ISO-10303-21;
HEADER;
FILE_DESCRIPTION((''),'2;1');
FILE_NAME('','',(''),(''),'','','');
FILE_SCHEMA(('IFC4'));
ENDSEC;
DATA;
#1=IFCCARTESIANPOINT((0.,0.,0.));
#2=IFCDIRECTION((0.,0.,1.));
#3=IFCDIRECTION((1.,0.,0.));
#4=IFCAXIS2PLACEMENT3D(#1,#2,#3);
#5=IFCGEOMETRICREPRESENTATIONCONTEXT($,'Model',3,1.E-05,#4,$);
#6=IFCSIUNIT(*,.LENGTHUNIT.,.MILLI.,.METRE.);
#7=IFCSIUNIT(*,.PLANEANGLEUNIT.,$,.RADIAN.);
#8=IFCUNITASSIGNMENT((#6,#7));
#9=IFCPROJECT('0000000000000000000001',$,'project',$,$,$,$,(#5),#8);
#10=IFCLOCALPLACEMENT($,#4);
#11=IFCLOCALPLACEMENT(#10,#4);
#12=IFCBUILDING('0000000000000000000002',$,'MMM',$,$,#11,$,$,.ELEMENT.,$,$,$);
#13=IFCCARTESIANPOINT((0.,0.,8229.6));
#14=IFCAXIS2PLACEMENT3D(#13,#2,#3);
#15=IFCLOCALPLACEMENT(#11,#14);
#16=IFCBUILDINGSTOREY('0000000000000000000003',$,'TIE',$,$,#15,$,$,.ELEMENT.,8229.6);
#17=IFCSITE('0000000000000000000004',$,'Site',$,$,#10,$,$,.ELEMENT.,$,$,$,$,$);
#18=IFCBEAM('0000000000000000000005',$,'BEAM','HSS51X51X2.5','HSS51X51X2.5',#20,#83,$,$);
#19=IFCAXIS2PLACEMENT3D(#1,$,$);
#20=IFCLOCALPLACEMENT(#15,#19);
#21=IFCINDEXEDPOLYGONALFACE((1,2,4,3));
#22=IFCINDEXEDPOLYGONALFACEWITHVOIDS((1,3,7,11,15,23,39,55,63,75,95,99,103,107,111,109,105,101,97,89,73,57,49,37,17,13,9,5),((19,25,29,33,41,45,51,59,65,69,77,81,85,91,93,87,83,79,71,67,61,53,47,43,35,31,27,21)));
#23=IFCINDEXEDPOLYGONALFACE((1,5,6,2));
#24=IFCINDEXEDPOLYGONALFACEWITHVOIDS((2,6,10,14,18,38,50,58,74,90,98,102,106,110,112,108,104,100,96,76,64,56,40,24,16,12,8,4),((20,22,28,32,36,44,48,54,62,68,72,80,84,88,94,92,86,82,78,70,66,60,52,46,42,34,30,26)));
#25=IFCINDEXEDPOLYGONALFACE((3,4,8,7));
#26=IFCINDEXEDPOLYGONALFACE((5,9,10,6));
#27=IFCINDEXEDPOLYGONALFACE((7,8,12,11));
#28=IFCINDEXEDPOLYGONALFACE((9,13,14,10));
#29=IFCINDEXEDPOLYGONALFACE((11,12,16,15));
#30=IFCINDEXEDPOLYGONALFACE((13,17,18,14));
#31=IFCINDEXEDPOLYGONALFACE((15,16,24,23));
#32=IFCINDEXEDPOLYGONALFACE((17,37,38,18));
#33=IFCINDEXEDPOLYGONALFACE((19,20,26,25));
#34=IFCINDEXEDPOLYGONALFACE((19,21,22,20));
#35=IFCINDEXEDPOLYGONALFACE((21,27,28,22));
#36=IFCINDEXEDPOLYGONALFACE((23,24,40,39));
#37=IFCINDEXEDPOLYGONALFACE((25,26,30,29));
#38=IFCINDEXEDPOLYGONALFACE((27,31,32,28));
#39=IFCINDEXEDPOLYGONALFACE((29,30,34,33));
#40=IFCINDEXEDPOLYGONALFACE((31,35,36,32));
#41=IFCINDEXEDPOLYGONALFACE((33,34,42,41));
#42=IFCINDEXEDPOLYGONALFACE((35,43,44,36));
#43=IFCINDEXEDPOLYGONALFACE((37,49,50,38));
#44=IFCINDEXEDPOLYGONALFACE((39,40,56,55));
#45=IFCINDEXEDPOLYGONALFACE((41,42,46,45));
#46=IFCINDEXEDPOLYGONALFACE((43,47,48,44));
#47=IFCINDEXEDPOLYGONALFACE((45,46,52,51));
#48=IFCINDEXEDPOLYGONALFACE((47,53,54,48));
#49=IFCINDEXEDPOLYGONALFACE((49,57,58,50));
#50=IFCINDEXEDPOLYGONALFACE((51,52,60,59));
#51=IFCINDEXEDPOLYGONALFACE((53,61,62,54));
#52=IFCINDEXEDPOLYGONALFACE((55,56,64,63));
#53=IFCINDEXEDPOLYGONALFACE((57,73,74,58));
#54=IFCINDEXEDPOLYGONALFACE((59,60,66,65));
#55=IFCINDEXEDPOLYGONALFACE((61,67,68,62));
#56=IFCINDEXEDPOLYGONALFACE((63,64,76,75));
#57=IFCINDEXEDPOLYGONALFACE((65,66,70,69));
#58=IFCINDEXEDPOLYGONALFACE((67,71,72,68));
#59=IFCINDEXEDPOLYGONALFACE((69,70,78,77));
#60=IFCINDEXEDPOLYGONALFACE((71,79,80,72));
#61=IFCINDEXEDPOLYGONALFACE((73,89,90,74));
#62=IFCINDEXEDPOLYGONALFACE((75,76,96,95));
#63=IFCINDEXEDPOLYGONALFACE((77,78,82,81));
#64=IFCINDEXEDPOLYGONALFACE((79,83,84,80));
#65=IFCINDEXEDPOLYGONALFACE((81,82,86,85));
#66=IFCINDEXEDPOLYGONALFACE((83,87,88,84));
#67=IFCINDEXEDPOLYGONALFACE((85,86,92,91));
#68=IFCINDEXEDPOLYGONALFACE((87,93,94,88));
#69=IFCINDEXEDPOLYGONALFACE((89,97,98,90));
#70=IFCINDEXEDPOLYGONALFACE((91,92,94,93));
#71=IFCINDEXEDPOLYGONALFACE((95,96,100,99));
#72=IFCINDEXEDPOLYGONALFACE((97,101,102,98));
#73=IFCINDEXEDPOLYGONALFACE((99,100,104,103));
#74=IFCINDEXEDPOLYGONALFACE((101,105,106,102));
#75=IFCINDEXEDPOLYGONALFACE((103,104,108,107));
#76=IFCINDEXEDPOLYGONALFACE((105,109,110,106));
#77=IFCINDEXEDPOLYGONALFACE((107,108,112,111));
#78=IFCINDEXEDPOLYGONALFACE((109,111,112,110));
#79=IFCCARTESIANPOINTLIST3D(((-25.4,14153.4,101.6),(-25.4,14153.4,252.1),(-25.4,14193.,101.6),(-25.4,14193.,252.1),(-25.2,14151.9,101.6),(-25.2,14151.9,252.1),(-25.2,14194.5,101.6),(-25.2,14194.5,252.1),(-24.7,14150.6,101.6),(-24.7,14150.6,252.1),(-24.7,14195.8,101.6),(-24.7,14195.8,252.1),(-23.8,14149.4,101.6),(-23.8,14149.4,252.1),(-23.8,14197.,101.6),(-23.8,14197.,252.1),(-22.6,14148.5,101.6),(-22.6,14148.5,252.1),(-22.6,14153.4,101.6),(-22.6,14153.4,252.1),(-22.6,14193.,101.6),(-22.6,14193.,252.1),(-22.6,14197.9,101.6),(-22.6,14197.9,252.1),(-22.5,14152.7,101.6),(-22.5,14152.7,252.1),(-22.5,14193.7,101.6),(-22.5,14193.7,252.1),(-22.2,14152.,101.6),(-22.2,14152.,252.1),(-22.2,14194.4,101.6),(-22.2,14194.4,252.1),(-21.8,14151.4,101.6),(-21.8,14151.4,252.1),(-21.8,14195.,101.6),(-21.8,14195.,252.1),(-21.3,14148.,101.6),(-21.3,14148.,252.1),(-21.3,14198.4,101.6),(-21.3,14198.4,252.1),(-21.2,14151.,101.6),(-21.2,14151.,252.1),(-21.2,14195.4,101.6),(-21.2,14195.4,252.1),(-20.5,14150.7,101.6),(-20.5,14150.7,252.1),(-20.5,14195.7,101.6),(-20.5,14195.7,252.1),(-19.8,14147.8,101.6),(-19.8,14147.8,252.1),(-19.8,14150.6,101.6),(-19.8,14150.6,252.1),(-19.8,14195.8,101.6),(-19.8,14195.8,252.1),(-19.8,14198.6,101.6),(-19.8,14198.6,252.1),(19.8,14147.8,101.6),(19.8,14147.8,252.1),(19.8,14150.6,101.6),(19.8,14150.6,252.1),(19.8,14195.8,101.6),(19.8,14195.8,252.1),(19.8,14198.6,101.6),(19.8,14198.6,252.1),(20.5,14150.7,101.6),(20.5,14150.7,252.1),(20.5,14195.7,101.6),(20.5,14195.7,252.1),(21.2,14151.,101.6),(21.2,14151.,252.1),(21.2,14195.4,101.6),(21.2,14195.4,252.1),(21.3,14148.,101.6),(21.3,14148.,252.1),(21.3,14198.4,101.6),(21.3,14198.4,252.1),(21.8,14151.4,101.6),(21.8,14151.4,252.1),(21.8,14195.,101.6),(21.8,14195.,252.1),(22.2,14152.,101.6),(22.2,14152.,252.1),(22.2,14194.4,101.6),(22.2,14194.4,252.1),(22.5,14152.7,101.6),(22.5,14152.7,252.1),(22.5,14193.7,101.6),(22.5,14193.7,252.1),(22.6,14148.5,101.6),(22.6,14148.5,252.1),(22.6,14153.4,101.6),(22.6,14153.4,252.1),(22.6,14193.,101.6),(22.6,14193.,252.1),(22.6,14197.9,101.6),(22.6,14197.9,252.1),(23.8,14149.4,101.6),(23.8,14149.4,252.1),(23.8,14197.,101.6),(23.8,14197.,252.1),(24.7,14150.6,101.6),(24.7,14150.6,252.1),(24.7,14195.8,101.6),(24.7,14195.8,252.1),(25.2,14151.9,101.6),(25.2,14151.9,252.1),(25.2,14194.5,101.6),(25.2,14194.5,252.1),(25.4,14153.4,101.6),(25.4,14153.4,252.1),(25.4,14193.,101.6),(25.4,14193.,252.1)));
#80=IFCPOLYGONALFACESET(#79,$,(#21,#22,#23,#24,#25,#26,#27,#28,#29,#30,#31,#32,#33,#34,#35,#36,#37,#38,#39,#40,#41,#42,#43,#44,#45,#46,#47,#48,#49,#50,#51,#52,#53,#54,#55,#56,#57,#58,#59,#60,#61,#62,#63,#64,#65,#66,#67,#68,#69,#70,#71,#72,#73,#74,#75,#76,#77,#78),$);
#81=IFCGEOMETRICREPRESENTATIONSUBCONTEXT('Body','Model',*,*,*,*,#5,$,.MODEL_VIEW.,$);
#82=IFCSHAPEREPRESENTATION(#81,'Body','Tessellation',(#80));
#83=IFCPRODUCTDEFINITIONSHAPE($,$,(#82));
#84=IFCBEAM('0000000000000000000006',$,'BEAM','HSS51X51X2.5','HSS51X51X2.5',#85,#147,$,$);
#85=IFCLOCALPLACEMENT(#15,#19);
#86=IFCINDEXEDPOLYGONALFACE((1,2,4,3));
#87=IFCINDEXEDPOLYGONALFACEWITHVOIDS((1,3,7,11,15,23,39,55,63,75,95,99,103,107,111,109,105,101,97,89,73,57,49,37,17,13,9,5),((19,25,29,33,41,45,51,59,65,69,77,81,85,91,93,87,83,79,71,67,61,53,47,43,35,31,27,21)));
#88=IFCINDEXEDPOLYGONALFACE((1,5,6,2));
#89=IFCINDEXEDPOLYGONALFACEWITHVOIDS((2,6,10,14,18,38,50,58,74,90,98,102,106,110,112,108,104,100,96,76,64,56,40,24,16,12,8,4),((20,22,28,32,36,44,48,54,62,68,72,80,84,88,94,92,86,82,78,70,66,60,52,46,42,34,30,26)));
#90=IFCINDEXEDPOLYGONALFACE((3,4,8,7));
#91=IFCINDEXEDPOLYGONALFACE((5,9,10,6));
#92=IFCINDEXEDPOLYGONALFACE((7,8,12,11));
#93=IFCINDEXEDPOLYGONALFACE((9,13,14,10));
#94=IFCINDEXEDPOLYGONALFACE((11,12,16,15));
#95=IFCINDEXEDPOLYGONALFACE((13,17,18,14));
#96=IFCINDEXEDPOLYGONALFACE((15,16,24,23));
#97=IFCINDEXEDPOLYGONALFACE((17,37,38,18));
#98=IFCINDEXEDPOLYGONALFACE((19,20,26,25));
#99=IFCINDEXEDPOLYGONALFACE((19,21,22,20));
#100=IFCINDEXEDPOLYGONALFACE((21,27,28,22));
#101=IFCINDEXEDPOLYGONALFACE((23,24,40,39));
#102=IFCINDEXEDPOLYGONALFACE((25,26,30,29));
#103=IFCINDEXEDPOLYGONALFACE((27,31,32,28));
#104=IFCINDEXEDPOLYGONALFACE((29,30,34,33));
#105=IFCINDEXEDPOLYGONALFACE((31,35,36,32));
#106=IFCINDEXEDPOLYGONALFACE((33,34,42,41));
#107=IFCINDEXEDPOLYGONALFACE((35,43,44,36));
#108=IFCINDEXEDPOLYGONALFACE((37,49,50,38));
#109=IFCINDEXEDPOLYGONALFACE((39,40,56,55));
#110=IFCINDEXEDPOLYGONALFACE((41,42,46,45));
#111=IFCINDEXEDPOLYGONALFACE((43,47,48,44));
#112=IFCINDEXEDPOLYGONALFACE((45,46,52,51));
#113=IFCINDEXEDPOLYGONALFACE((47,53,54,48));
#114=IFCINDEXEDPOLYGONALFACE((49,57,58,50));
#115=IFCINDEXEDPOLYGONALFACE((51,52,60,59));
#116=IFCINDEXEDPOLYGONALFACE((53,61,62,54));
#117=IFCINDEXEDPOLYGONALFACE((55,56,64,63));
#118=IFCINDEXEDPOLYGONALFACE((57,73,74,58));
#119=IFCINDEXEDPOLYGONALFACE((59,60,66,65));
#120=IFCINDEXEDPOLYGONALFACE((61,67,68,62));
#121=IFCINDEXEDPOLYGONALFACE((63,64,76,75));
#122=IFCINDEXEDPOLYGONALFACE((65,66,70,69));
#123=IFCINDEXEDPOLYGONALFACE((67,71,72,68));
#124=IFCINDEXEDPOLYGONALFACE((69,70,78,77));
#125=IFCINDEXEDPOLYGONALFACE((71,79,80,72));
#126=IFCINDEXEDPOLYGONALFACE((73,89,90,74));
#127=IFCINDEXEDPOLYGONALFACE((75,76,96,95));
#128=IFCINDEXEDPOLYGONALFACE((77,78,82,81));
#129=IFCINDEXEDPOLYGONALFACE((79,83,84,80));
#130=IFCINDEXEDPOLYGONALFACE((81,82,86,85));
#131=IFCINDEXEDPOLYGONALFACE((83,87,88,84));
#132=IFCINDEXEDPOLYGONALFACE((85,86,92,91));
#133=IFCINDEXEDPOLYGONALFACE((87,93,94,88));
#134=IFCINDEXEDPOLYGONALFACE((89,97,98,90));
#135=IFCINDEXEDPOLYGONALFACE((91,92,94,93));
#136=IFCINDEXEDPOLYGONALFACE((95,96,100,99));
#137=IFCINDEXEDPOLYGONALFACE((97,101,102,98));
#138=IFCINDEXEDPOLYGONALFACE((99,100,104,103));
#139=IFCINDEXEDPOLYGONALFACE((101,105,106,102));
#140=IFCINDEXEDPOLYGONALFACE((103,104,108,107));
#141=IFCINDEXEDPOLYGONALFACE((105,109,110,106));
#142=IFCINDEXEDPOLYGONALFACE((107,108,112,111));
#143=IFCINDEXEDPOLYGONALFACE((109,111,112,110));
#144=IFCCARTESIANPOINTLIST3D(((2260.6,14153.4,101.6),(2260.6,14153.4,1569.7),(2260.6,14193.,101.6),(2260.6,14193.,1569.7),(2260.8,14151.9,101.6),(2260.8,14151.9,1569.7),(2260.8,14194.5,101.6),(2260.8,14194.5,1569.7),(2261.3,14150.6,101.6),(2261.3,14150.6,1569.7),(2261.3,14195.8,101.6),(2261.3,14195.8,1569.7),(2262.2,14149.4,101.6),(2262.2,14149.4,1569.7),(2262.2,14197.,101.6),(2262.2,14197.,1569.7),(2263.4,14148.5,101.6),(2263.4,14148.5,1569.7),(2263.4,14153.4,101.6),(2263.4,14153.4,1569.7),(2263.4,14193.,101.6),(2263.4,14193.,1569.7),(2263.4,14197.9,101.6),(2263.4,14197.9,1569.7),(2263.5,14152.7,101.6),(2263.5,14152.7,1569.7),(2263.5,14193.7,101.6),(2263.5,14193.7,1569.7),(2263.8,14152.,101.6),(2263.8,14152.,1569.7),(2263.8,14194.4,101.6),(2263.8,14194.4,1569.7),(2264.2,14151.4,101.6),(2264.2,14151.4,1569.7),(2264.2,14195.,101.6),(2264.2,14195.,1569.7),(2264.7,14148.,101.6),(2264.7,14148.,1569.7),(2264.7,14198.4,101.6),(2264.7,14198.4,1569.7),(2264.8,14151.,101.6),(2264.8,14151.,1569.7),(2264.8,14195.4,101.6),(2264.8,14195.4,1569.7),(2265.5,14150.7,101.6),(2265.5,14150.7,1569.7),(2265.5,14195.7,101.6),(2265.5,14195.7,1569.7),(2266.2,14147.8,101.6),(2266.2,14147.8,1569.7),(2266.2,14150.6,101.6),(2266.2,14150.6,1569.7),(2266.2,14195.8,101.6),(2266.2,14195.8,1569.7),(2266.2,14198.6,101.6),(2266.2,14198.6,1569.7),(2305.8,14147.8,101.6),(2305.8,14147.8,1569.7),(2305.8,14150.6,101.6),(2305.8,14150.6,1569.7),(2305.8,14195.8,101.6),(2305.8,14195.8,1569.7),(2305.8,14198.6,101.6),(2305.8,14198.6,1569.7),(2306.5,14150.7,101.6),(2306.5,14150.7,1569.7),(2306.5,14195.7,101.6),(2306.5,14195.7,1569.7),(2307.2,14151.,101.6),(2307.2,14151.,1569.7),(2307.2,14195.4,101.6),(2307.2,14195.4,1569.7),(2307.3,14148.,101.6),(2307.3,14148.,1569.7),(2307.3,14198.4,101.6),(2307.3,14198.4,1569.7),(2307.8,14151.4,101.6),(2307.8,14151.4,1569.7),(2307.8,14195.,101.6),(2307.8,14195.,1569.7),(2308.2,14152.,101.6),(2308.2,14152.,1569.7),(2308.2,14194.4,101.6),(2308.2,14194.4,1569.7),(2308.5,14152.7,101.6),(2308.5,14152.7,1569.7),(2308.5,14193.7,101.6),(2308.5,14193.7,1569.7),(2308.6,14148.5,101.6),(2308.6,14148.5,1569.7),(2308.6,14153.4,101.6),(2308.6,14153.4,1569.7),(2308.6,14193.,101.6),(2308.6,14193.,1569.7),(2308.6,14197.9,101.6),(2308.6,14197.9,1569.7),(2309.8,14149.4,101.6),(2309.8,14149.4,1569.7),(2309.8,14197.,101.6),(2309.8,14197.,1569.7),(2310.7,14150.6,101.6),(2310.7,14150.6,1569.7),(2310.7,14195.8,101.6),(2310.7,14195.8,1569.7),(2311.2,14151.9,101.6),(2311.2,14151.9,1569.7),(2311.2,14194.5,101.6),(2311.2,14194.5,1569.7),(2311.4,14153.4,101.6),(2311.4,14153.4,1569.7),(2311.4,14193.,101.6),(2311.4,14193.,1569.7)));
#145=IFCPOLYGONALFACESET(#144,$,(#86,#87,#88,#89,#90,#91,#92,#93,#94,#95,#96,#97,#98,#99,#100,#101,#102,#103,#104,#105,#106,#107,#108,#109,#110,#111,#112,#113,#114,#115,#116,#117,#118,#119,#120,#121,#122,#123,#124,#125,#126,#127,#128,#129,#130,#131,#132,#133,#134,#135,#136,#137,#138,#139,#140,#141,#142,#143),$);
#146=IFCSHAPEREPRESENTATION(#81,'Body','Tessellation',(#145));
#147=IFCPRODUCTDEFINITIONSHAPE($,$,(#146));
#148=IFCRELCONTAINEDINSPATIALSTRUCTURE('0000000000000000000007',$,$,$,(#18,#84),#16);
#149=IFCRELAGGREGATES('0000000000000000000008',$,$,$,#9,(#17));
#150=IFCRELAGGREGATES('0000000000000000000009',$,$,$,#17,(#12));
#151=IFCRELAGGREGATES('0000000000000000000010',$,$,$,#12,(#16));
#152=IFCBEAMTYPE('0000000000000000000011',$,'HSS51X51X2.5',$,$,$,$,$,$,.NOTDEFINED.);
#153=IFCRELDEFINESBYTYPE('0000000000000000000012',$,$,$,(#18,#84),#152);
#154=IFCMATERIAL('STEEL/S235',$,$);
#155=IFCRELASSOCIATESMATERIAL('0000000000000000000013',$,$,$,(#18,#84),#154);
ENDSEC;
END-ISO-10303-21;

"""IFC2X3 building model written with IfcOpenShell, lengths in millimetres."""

from ifc_helpers import new_model, si_unit, frame, origin_with_axes, origin_2d_with_axis, place, context, subcontext, project, spatial, hollow_rectangle, extrude, material, type_object, element, save


model = new_model("IFC2X3")

# Units and contexts
model_context = context("Model", 3, precision=1e-05, world=origin_with_axes())
body_context = subcontext(model_context, "Body", "Model", "MODEL_VIEW")
ifc_project = project(units=[si_unit("LENGTHUNIT", "METRE", prefix="MILLI"), si_unit("PLANEANGLEUNIT", "RADIAN")], contexts=[model_context])

# Site, building, storey
site_placement = place(None, origin_with_axes())
site = spatial("IfcSite", under=ifc_project, at=site_placement, Name="Site", CompositionType="ELEMENT")
building_placement = place(site_placement, origin_with_axes())
building = spatial("IfcBuilding", under=site, at=building_placement, Name="MMM", CompositionType="ELEMENT")
storey_placement = place(building_placement, frame((0.0, 0.0, 8229.6), z_axis=(0.0, 0.0, 1.0), x_axis=(1.0, 0.0, 0.0)))
storey = spatial("IfcBuildingStorey", under=building, at=storey_placement, Name="TIE", CompositionType="ELEMENT", Elevation=8229.6)

# Beams
ifc_material = material(Name="STEEL/S235")
beam_type_1 = type_object("IfcBeamType", Name="HSS51X51X2.5", PredefinedType="NOTDEFINED")
beam_1_placement = place(storey_placement, frame((0.0, 14173.2, 252.1), z_axis=(1.0, 0.0, 0.0), x_axis=(0.0, 0.0, -1.0)))
element("IfcBeam", 1, at=beam_1_placement, inside=storey, type_object=beam_type_1, material=ifc_material, Name="BEAM", Description="HSS51X51X2.5", ObjectType="HSS51X51X2.5", context=body_context, shape_type="SweptSolid", body=[
    extrude(hollow_rectangle(XDim=50.8, YDim=50.8, WallThickness=2.8, InnerFilletRadius=2.8, OuterFilletRadius=5.6, at=origin_2d_with_axis()), frame((150.5, 0.0, 0.0), z_axis=(-1.0, 0.0, 0.0), x_axis=(0.0, -1.0, 0.0)), (0.0, 0.0, 1.0), 150.5),
])
beam_2_placement = place(storey_placement, frame((2286.0, 14173.2, 1569.7), z_axis=(1.0, 0.0, 0.0), x_axis=(0.0, 0.0, -1.0)))
element("IfcBeam", 2, at=beam_2_placement, inside=storey, type_object=beam_type_1, material=ifc_material, Name="BEAM", Description="HSS51X51X2.5", ObjectType="HSS51X51X2.5", context=body_context, shape_type="SweptSolid", body=[
    extrude(hollow_rectangle(XDim=50.8, YDim=50.8, WallThickness=2.8, InnerFilletRadius=2.8, OuterFilletRadius=5.6, at=origin_2d_with_axis()), frame((1468.1, 0.0, 0.0), z_axis=(-1.0, 0.0, 0.0), x_axis=(0.0, -1.0, 0.0)), (0.0, 0.0, 1.0), 1468.1),
])

save(model, "model.ifc")
